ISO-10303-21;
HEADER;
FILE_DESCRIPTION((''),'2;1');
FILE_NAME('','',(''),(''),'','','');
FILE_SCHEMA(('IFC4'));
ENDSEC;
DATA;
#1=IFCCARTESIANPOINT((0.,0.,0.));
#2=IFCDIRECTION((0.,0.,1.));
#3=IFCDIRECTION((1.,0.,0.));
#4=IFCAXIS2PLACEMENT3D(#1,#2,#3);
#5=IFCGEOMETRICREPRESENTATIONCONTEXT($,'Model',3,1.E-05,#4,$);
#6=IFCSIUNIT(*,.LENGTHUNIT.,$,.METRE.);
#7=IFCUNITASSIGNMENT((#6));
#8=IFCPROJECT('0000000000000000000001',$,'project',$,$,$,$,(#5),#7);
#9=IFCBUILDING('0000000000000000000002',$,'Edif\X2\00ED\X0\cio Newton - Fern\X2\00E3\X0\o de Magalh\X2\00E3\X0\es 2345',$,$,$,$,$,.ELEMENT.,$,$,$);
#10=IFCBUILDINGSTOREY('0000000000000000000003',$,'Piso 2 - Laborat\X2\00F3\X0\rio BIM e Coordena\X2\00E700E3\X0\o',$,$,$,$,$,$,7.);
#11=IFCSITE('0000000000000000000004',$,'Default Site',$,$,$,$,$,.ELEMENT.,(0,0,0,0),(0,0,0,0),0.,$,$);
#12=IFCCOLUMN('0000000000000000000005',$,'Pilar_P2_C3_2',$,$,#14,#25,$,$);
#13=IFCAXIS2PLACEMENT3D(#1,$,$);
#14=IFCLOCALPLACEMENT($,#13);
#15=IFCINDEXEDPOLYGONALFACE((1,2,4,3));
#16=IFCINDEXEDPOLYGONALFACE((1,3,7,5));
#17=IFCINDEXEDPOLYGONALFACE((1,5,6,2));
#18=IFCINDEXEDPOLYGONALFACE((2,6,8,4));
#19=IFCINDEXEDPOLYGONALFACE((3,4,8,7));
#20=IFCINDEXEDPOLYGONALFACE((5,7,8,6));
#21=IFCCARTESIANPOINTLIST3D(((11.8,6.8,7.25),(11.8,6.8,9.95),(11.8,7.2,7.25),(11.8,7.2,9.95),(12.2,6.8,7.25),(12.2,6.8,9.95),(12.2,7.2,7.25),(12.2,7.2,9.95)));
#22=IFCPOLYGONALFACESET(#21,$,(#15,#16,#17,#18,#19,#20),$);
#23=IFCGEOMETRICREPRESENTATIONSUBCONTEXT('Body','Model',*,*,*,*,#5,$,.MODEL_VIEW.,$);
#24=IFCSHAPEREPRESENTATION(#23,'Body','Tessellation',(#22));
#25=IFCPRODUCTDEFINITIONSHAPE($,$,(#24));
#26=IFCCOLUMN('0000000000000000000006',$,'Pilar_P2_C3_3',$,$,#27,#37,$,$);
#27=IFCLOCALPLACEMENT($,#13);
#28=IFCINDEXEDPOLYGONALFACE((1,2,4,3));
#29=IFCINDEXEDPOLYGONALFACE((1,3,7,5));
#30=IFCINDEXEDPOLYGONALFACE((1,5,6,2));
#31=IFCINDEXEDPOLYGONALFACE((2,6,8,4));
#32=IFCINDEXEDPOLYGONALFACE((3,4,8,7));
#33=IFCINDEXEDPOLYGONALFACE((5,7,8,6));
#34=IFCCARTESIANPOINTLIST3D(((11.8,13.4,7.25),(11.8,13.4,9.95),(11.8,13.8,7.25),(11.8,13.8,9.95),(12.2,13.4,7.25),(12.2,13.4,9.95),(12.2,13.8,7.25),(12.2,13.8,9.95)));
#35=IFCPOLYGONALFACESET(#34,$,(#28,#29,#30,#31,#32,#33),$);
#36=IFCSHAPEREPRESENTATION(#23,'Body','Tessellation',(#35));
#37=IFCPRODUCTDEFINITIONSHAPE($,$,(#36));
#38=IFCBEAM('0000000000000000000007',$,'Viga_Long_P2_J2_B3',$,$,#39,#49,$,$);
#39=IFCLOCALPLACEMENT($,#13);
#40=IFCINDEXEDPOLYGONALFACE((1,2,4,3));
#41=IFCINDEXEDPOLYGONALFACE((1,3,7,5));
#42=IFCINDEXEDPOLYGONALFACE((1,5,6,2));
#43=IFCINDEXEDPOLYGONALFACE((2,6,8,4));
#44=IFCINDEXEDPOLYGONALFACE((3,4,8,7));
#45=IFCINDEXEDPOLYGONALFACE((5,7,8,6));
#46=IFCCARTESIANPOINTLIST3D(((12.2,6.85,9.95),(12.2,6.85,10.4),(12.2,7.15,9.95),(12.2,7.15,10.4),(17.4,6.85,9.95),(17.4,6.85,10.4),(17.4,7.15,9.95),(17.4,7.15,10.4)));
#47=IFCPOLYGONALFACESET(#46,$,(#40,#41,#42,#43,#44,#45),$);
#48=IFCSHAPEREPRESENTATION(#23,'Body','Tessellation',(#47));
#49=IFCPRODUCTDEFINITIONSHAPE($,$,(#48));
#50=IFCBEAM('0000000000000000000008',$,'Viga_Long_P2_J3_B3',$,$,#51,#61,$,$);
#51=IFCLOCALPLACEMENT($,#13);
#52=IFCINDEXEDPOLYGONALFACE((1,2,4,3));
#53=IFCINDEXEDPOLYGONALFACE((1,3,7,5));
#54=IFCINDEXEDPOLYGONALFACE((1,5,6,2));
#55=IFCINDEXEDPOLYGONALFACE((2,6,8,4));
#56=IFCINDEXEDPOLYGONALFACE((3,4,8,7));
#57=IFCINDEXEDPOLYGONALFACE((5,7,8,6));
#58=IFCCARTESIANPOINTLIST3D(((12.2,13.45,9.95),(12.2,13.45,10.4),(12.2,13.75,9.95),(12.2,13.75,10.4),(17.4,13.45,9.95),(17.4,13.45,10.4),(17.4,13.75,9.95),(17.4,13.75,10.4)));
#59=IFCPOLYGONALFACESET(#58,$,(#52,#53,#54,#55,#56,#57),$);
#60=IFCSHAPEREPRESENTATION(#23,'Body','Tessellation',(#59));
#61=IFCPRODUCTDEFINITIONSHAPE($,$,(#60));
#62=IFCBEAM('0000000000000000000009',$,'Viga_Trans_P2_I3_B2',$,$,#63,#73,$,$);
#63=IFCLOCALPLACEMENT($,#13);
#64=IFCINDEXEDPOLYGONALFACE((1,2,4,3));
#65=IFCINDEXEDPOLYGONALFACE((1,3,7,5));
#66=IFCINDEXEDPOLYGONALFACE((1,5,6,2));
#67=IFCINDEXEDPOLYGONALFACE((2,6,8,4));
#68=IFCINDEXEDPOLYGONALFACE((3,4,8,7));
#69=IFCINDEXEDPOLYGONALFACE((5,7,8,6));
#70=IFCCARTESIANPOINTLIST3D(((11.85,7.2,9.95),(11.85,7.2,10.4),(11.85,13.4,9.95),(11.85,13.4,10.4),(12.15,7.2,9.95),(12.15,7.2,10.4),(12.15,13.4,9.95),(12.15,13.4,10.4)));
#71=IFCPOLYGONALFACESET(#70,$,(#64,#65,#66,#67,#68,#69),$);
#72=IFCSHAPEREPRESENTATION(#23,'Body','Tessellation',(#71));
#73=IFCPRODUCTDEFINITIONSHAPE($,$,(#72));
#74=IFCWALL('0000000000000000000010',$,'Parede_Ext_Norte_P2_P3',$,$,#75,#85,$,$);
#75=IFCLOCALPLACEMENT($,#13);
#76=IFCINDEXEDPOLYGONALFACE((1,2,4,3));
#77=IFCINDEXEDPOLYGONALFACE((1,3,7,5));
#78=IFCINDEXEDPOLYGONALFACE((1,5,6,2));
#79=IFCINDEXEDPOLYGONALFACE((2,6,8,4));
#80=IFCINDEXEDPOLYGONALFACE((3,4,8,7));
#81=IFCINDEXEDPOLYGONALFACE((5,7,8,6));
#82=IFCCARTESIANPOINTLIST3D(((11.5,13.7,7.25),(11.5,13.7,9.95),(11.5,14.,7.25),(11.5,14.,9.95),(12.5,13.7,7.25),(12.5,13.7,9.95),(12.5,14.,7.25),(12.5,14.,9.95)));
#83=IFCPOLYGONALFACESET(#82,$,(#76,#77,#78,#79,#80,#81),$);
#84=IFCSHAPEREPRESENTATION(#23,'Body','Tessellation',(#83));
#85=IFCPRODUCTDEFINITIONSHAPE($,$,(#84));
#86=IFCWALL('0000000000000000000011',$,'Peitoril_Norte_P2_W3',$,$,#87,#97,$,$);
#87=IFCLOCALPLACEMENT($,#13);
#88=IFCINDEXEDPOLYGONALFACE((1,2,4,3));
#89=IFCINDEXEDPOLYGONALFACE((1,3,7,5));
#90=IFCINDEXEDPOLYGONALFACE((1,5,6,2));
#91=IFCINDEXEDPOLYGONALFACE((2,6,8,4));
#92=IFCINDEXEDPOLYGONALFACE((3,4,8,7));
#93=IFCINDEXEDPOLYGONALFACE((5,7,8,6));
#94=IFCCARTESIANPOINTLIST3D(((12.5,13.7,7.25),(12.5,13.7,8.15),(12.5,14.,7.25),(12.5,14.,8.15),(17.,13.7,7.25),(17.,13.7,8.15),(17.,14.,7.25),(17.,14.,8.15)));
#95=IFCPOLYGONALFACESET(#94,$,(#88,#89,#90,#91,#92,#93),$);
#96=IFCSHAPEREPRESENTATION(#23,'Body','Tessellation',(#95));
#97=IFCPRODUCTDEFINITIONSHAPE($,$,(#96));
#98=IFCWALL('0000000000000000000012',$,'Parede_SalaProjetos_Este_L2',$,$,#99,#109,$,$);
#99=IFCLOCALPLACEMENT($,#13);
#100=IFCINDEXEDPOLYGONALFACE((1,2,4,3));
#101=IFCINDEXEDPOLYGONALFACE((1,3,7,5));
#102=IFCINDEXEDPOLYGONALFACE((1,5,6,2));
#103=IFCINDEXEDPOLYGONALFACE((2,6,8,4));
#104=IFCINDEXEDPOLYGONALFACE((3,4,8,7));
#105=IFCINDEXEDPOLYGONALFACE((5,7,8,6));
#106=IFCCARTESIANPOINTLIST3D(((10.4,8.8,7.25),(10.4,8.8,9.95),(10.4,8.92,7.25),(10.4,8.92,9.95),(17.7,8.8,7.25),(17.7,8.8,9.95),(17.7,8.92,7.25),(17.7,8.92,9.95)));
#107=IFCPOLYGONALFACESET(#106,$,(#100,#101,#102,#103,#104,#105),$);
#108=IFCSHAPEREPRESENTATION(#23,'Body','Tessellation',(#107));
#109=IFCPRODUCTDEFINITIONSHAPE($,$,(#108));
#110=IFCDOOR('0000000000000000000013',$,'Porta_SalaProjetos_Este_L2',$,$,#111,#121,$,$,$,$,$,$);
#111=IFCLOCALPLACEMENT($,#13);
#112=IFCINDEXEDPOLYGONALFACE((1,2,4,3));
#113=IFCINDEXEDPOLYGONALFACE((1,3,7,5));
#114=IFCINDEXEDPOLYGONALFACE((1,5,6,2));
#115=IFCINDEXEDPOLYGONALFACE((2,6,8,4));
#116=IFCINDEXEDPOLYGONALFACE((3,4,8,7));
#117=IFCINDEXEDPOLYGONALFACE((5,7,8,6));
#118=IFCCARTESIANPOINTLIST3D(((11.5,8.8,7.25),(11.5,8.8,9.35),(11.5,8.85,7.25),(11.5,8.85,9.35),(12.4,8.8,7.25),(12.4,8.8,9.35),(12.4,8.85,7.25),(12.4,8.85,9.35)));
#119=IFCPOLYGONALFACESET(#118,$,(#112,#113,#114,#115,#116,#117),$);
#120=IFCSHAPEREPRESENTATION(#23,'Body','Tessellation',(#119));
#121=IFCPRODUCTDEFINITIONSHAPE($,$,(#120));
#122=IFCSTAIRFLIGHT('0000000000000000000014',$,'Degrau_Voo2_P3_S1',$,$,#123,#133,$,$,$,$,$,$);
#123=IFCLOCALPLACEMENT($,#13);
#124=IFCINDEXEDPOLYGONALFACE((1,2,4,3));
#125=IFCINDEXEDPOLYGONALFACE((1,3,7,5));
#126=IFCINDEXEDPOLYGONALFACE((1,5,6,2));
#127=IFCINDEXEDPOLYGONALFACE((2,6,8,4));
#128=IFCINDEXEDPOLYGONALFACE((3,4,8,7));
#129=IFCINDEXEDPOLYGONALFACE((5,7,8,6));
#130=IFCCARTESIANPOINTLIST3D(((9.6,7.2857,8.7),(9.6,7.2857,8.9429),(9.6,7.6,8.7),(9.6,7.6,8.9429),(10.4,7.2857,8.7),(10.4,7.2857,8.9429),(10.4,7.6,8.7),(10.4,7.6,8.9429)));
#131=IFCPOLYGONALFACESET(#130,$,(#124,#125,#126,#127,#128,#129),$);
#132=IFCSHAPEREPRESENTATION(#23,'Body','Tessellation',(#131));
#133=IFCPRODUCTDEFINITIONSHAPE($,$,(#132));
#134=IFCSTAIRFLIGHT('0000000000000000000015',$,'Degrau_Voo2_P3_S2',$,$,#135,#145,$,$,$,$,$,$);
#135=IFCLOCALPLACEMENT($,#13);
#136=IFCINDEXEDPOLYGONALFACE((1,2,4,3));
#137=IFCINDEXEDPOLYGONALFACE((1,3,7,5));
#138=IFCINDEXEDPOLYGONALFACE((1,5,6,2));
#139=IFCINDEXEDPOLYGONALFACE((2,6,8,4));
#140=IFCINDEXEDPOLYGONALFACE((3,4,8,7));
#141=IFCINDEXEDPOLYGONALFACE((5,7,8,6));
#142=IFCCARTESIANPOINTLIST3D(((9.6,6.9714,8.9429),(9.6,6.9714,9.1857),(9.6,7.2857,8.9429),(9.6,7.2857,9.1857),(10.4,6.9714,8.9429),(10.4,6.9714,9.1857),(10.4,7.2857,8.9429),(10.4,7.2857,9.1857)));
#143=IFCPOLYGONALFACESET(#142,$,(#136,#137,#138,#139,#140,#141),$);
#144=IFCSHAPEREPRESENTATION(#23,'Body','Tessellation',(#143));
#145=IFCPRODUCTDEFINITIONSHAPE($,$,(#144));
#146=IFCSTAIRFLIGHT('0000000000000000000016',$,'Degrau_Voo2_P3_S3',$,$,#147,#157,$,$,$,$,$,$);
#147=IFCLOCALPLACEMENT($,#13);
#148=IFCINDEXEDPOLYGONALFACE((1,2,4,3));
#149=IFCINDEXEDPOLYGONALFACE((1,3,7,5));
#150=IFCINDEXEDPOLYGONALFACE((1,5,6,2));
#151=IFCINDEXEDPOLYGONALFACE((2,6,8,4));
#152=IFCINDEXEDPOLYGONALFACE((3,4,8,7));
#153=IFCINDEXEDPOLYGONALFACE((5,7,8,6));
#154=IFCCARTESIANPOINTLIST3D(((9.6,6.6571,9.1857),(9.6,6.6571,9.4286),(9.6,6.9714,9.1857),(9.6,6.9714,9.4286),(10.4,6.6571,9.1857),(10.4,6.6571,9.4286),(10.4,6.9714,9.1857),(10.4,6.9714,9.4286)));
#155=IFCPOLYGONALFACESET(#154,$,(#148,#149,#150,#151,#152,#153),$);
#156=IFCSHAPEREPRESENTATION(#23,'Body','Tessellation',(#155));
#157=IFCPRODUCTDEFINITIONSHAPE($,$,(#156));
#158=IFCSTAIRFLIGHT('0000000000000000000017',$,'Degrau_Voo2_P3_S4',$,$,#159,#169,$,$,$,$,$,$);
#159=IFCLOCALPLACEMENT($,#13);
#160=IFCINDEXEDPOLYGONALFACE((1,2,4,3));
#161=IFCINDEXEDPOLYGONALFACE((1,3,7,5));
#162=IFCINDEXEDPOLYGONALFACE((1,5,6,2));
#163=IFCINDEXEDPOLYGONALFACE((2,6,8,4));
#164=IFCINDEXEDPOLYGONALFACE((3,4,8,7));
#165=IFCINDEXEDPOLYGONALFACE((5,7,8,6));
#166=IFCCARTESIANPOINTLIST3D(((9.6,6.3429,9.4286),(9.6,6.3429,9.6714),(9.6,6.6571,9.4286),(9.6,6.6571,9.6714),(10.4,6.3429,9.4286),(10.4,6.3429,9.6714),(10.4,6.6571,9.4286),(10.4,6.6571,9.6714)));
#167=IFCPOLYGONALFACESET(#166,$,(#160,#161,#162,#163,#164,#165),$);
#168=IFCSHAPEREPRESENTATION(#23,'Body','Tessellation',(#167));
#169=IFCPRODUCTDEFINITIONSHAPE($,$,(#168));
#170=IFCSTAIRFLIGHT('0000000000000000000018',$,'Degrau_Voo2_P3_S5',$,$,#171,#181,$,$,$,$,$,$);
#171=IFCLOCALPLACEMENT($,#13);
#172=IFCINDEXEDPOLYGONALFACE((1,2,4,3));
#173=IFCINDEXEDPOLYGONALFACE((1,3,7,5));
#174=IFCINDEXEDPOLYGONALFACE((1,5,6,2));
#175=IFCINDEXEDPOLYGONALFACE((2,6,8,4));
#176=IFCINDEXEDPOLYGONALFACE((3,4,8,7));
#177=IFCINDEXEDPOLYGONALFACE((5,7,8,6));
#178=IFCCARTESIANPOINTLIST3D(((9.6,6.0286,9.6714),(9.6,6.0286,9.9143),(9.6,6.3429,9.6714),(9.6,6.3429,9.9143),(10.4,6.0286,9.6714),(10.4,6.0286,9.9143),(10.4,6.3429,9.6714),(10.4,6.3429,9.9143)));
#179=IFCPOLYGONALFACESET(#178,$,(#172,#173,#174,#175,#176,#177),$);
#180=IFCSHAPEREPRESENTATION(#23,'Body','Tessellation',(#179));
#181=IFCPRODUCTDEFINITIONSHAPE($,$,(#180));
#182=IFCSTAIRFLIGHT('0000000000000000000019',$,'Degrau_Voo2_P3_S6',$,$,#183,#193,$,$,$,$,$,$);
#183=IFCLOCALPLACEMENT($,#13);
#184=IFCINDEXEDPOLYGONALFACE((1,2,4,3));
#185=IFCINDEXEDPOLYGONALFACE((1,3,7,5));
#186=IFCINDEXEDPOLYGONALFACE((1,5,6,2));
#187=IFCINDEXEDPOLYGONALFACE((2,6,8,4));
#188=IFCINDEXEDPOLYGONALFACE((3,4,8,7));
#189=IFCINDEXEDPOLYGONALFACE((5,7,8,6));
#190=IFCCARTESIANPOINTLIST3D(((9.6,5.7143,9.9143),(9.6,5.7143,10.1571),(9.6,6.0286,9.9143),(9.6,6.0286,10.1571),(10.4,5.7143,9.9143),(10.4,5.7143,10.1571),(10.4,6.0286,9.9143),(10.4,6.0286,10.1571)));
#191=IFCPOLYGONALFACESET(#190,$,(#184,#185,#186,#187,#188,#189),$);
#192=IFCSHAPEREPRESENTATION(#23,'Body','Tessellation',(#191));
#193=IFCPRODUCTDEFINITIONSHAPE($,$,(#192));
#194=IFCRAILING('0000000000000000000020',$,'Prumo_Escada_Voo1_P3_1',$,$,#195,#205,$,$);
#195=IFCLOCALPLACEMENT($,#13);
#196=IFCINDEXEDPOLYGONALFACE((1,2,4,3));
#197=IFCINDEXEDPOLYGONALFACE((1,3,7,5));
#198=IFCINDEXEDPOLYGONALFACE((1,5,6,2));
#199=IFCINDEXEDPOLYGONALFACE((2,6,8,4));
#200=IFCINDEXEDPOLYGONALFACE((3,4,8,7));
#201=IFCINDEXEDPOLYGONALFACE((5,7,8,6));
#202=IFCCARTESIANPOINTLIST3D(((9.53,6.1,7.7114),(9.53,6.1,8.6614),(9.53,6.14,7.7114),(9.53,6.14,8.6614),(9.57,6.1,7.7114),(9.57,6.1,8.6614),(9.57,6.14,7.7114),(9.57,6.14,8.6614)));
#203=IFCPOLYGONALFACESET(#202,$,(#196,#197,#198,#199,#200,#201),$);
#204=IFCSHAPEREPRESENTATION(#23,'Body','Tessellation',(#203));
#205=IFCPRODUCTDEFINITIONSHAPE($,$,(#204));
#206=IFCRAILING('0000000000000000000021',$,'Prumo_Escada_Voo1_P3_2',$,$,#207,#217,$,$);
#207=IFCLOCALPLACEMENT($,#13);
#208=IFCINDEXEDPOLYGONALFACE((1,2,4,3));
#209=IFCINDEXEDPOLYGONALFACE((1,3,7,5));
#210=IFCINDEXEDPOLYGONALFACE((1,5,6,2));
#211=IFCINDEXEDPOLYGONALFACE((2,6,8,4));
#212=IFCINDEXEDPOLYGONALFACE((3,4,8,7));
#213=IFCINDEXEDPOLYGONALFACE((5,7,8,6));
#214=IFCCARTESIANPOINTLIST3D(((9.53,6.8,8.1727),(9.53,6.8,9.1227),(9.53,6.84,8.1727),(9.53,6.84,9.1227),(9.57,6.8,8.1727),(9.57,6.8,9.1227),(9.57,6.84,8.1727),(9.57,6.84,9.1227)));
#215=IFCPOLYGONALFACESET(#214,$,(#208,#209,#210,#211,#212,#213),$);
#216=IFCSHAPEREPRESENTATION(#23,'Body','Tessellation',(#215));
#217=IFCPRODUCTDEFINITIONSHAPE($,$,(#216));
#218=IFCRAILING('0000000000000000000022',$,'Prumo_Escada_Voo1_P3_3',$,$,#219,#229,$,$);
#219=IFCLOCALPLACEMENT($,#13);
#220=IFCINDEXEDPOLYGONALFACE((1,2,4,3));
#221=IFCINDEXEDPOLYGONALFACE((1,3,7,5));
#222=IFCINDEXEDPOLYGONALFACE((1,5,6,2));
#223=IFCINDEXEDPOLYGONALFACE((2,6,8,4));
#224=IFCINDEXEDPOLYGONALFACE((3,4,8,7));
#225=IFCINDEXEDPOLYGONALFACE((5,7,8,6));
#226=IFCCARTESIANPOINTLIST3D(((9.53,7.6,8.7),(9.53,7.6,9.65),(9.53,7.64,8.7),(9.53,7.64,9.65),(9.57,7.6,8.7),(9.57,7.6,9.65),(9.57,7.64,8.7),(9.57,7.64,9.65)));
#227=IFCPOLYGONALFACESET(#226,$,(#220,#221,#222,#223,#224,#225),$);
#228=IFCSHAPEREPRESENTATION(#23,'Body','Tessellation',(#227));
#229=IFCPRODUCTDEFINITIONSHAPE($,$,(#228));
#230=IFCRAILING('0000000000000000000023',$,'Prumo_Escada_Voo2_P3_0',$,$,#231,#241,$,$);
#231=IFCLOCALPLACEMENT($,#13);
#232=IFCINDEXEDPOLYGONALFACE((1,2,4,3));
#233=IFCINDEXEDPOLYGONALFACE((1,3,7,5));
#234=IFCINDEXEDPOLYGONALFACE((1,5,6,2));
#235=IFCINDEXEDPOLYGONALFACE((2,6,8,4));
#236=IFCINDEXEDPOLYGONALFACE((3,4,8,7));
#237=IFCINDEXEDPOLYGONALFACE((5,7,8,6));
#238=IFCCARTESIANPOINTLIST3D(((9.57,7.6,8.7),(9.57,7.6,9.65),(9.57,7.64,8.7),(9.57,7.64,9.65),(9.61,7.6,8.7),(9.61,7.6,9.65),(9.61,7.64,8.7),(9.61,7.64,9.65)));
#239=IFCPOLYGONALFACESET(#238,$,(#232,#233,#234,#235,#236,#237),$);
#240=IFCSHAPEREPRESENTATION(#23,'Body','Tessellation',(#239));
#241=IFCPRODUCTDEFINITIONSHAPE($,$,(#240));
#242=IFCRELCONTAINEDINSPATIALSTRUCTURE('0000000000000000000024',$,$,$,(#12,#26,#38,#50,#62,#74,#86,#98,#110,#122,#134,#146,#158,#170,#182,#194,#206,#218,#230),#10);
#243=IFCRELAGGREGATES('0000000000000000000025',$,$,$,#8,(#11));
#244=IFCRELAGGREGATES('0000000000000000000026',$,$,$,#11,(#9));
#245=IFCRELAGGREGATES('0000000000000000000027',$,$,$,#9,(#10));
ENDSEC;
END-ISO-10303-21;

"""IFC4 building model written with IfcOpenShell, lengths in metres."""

from ifc_helpers import new_model, si_unit, frame, frame_2d, origin_with_axes, place, context, subcontext, project, spatial, rectangle, extrude, element, save


model = new_model("IFC4")

# Units and contexts
model_context = context("Model", 3, precision=1e-05, world=origin_with_axes())
body_context = subcontext(model_context, "Body", "Model", "MODEL_VIEW")
ifc_project = project(units=[si_unit("LENGTHUNIT", "METRE")], contexts=[model_context])

# Site, building, storey
site = spatial("IfcSite", under=ifc_project, Name="Default Site", CompositionType="ELEMENT", RefLatitude=(0, 0, 0, 0), RefLongitude=(0, 0, 0, 0), RefElevation=0.0)
building = spatial("IfcBuilding", under=site, Name="Edifício Newton - Fernão de Magalhães 2345", CompositionType="ELEMENT")
storey = spatial("IfcBuildingStorey", under=building, Name="Piso 2 - Laboratório BIM e Coordenação", Elevation=7.0)

# Columns
for number, where, z_axis, x_axis, name in (
    (1, (11.8, 6.8, 7.25), (0.0, 0.0, 1.0), (1.0, 0.0, 0.0), "Pilar_P2_C3_2"),
    (2, (11.8, 13.4, 7.25), (0.0, 0.0, 1.0), (1.0, 0.0, 0.0), "Pilar_P2_C3_3"),
):
    element("IfcColumn", number, at=place(None, frame(where, z_axis=z_axis, x_axis=x_axis)), inside=storey, Name=name, context=body_context, shape_type="SweptSolid", body=[
        extrude(rectangle(XDim=0.4, YDim=0.4, at=frame_2d((0.2, 0.2))), origin_with_axes(), (0.0, 0.0, 1.0), 2.7),
    ])

# Beams
for number, where, z_axis, x_axis, name in (
    (3, (12.2, 6.85, 9.95), (0.0, 0.0, 1.0), (1.0, 0.0, 0.0), "Viga_Long_P2_J2_B3"),
    (4, (12.2, 13.45, 9.95), (0.0, 0.0, 1.0), (1.0, 0.0, 0.0), "Viga_Long_P2_J3_B3"),
):
    element("IfcBeam", number, at=place(None, frame(where, z_axis=z_axis, x_axis=x_axis)), inside=storey, Name=name, context=body_context, shape_type="SweptSolid", body=[
        extrude(rectangle(XDim=5.2, YDim=0.3, at=frame_2d((2.6, 0.15))), origin_with_axes(), (0.0, 0.0, 1.0), 0.45),
    ])
beam_placement = place(None, frame((11.85, 7.2, 9.95), z_axis=(0.0, 0.0, 1.0), x_axis=(1.0, 0.0, 0.0)))
element("IfcBeam", 5, at=beam_placement, inside=storey, Name="Viga_Trans_P2_I3_B2", context=body_context, shape_type="SweptSolid", body=[
    extrude(rectangle(XDim=0.3, YDim=6.2, at=frame_2d((0.15, 3.1))), origin_with_axes(), (0.0, 0.0, 1.0), 0.45),
])

# Walls
wall_1_placement = place(None, frame((11.5, 13.7, 7.25), z_axis=(0.0, 0.0, 1.0), x_axis=(1.0, 0.0, 0.0)))
element("IfcWall", 6, at=wall_1_placement, inside=storey, Name="Parede_Ext_Norte_P2_P3", context=body_context, shape_type="SweptSolid", body=[
    extrude(rectangle(XDim=1.0, YDim=0.3, at=frame_2d((0.5, 0.15))), origin_with_axes(), (0.0, 0.0, 1.0), 2.7),
])
wall_2_placement = place(None, frame((12.5, 13.7, 7.25), z_axis=(0.0, 0.0, 1.0), x_axis=(1.0, 0.0, 0.0)))
element("IfcWall", 7, at=wall_2_placement, inside=storey, Name="Peitoril_Norte_P2_W3", context=body_context, shape_type="SweptSolid", body=[
    extrude(rectangle(XDim=4.5, YDim=0.3, at=frame_2d((2.25, 0.15))), origin_with_axes(), (0.0, 0.0, 1.0), 0.9),
])
wall_3_placement = place(None, frame((10.4, 8.8, 7.25), z_axis=(0.0, 0.0, 1.0), x_axis=(1.0, 0.0, 0.0)))
element("IfcWall", 8, at=wall_3_placement, inside=storey, Name="Parede_SalaProjetos_Este_L2", context=body_context, shape_type="SweptSolid", body=[
    extrude(rectangle(XDim=7.3, YDim=0.12, at=frame_2d((3.65, 0.06))), origin_with_axes(), (0.0, 0.0, 1.0), 2.7),
])

# Door
door_placement = place(None, frame((11.5, 8.8, 7.25), z_axis=(0.0, 0.0, 1.0), x_axis=(1.0, 0.0, 0.0)))
element("IfcDoor", 9, at=door_placement, inside=storey, Name="Porta_SalaProjetos_Este_L2", context=body_context, shape_type="SweptSolid", body=[
    extrude(rectangle(XDim=0.9, YDim=0.05, at=frame_2d((0.45, 0.025))), origin_with_axes(), (0.0, 0.0, 1.0), 2.1),
])

# Stair flights
for number, where, z_axis, x_axis, name in (
    (10, (9.6, 7.2857, 8.7), (0.0, 0.0, 1.0), (1.0, 0.0, 0.0), "Degrau_Voo2_P3_S1"),
    (11, (9.6, 6.9714, 8.9429), (0.0, 0.0, 1.0), (1.0, 0.0, 0.0), "Degrau_Voo2_P3_S2"),
    (12, (9.6, 6.6571, 9.1857), (0.0, 0.0, 1.0), (1.0, 0.0, 0.0), "Degrau_Voo2_P3_S3"),
    (13, (9.6, 6.3429, 9.4286), (0.0, 0.0, 1.0), (1.0, 0.0, 0.0), "Degrau_Voo2_P3_S4"),
    (14, (9.6, 6.0286, 9.6714), (0.0, 0.0, 1.0), (1.0, 0.0, 0.0), "Degrau_Voo2_P3_S5"),
    (15, (9.6, 5.7143, 9.9143), (0.0, 0.0, 1.0), (1.0, 0.0, 0.0), "Degrau_Voo2_P3_S6"),
):
    element("IfcStairFlight", number, at=place(None, frame(where, z_axis=z_axis, x_axis=x_axis)), inside=storey, Name=name, context=body_context, shape_type="SweptSolid", body=[
        extrude(rectangle(XDim=0.8, YDim=0.3143, at=frame_2d((0.4, 0.1571))), origin_with_axes(), (0.0, 0.0, 1.0), 0.2429),
    ])

# Railings
for number, where, z_axis, x_axis, name in (
    (16, (9.53, 6.1, 7.7114), (0.0, 0.0, 1.0), (1.0, 0.0, 0.0), "Prumo_Escada_Voo1_P3_1"),
    (17, (9.53, 6.8, 8.1727), (0.0, 0.0, 1.0), (1.0, 0.0, 0.0), "Prumo_Escada_Voo1_P3_2"),
    (18, (9.53, 7.6, 8.7), (0.0, 0.0, 1.0), (1.0, 0.0, 0.0), "Prumo_Escada_Voo1_P3_3"),
    (19, (9.57, 7.6, 8.7), (0.0, 0.0, 1.0), (1.0, 0.0, 0.0), "Prumo_Escada_Voo2_P3_0"),
):
    element("IfcRailing", number, at=place(None, frame(where, z_axis=z_axis, x_axis=x_axis)), inside=storey, Name=name, context=body_context, shape_type="SweptSolid", body=[
        extrude(rectangle(XDim=0.04, YDim=0.04, at=frame_2d((0.02, 0.02))), origin_with_axes(), (0.0, 0.0, 1.0), 0.95),
    ])

save(model, "model.ifc")
